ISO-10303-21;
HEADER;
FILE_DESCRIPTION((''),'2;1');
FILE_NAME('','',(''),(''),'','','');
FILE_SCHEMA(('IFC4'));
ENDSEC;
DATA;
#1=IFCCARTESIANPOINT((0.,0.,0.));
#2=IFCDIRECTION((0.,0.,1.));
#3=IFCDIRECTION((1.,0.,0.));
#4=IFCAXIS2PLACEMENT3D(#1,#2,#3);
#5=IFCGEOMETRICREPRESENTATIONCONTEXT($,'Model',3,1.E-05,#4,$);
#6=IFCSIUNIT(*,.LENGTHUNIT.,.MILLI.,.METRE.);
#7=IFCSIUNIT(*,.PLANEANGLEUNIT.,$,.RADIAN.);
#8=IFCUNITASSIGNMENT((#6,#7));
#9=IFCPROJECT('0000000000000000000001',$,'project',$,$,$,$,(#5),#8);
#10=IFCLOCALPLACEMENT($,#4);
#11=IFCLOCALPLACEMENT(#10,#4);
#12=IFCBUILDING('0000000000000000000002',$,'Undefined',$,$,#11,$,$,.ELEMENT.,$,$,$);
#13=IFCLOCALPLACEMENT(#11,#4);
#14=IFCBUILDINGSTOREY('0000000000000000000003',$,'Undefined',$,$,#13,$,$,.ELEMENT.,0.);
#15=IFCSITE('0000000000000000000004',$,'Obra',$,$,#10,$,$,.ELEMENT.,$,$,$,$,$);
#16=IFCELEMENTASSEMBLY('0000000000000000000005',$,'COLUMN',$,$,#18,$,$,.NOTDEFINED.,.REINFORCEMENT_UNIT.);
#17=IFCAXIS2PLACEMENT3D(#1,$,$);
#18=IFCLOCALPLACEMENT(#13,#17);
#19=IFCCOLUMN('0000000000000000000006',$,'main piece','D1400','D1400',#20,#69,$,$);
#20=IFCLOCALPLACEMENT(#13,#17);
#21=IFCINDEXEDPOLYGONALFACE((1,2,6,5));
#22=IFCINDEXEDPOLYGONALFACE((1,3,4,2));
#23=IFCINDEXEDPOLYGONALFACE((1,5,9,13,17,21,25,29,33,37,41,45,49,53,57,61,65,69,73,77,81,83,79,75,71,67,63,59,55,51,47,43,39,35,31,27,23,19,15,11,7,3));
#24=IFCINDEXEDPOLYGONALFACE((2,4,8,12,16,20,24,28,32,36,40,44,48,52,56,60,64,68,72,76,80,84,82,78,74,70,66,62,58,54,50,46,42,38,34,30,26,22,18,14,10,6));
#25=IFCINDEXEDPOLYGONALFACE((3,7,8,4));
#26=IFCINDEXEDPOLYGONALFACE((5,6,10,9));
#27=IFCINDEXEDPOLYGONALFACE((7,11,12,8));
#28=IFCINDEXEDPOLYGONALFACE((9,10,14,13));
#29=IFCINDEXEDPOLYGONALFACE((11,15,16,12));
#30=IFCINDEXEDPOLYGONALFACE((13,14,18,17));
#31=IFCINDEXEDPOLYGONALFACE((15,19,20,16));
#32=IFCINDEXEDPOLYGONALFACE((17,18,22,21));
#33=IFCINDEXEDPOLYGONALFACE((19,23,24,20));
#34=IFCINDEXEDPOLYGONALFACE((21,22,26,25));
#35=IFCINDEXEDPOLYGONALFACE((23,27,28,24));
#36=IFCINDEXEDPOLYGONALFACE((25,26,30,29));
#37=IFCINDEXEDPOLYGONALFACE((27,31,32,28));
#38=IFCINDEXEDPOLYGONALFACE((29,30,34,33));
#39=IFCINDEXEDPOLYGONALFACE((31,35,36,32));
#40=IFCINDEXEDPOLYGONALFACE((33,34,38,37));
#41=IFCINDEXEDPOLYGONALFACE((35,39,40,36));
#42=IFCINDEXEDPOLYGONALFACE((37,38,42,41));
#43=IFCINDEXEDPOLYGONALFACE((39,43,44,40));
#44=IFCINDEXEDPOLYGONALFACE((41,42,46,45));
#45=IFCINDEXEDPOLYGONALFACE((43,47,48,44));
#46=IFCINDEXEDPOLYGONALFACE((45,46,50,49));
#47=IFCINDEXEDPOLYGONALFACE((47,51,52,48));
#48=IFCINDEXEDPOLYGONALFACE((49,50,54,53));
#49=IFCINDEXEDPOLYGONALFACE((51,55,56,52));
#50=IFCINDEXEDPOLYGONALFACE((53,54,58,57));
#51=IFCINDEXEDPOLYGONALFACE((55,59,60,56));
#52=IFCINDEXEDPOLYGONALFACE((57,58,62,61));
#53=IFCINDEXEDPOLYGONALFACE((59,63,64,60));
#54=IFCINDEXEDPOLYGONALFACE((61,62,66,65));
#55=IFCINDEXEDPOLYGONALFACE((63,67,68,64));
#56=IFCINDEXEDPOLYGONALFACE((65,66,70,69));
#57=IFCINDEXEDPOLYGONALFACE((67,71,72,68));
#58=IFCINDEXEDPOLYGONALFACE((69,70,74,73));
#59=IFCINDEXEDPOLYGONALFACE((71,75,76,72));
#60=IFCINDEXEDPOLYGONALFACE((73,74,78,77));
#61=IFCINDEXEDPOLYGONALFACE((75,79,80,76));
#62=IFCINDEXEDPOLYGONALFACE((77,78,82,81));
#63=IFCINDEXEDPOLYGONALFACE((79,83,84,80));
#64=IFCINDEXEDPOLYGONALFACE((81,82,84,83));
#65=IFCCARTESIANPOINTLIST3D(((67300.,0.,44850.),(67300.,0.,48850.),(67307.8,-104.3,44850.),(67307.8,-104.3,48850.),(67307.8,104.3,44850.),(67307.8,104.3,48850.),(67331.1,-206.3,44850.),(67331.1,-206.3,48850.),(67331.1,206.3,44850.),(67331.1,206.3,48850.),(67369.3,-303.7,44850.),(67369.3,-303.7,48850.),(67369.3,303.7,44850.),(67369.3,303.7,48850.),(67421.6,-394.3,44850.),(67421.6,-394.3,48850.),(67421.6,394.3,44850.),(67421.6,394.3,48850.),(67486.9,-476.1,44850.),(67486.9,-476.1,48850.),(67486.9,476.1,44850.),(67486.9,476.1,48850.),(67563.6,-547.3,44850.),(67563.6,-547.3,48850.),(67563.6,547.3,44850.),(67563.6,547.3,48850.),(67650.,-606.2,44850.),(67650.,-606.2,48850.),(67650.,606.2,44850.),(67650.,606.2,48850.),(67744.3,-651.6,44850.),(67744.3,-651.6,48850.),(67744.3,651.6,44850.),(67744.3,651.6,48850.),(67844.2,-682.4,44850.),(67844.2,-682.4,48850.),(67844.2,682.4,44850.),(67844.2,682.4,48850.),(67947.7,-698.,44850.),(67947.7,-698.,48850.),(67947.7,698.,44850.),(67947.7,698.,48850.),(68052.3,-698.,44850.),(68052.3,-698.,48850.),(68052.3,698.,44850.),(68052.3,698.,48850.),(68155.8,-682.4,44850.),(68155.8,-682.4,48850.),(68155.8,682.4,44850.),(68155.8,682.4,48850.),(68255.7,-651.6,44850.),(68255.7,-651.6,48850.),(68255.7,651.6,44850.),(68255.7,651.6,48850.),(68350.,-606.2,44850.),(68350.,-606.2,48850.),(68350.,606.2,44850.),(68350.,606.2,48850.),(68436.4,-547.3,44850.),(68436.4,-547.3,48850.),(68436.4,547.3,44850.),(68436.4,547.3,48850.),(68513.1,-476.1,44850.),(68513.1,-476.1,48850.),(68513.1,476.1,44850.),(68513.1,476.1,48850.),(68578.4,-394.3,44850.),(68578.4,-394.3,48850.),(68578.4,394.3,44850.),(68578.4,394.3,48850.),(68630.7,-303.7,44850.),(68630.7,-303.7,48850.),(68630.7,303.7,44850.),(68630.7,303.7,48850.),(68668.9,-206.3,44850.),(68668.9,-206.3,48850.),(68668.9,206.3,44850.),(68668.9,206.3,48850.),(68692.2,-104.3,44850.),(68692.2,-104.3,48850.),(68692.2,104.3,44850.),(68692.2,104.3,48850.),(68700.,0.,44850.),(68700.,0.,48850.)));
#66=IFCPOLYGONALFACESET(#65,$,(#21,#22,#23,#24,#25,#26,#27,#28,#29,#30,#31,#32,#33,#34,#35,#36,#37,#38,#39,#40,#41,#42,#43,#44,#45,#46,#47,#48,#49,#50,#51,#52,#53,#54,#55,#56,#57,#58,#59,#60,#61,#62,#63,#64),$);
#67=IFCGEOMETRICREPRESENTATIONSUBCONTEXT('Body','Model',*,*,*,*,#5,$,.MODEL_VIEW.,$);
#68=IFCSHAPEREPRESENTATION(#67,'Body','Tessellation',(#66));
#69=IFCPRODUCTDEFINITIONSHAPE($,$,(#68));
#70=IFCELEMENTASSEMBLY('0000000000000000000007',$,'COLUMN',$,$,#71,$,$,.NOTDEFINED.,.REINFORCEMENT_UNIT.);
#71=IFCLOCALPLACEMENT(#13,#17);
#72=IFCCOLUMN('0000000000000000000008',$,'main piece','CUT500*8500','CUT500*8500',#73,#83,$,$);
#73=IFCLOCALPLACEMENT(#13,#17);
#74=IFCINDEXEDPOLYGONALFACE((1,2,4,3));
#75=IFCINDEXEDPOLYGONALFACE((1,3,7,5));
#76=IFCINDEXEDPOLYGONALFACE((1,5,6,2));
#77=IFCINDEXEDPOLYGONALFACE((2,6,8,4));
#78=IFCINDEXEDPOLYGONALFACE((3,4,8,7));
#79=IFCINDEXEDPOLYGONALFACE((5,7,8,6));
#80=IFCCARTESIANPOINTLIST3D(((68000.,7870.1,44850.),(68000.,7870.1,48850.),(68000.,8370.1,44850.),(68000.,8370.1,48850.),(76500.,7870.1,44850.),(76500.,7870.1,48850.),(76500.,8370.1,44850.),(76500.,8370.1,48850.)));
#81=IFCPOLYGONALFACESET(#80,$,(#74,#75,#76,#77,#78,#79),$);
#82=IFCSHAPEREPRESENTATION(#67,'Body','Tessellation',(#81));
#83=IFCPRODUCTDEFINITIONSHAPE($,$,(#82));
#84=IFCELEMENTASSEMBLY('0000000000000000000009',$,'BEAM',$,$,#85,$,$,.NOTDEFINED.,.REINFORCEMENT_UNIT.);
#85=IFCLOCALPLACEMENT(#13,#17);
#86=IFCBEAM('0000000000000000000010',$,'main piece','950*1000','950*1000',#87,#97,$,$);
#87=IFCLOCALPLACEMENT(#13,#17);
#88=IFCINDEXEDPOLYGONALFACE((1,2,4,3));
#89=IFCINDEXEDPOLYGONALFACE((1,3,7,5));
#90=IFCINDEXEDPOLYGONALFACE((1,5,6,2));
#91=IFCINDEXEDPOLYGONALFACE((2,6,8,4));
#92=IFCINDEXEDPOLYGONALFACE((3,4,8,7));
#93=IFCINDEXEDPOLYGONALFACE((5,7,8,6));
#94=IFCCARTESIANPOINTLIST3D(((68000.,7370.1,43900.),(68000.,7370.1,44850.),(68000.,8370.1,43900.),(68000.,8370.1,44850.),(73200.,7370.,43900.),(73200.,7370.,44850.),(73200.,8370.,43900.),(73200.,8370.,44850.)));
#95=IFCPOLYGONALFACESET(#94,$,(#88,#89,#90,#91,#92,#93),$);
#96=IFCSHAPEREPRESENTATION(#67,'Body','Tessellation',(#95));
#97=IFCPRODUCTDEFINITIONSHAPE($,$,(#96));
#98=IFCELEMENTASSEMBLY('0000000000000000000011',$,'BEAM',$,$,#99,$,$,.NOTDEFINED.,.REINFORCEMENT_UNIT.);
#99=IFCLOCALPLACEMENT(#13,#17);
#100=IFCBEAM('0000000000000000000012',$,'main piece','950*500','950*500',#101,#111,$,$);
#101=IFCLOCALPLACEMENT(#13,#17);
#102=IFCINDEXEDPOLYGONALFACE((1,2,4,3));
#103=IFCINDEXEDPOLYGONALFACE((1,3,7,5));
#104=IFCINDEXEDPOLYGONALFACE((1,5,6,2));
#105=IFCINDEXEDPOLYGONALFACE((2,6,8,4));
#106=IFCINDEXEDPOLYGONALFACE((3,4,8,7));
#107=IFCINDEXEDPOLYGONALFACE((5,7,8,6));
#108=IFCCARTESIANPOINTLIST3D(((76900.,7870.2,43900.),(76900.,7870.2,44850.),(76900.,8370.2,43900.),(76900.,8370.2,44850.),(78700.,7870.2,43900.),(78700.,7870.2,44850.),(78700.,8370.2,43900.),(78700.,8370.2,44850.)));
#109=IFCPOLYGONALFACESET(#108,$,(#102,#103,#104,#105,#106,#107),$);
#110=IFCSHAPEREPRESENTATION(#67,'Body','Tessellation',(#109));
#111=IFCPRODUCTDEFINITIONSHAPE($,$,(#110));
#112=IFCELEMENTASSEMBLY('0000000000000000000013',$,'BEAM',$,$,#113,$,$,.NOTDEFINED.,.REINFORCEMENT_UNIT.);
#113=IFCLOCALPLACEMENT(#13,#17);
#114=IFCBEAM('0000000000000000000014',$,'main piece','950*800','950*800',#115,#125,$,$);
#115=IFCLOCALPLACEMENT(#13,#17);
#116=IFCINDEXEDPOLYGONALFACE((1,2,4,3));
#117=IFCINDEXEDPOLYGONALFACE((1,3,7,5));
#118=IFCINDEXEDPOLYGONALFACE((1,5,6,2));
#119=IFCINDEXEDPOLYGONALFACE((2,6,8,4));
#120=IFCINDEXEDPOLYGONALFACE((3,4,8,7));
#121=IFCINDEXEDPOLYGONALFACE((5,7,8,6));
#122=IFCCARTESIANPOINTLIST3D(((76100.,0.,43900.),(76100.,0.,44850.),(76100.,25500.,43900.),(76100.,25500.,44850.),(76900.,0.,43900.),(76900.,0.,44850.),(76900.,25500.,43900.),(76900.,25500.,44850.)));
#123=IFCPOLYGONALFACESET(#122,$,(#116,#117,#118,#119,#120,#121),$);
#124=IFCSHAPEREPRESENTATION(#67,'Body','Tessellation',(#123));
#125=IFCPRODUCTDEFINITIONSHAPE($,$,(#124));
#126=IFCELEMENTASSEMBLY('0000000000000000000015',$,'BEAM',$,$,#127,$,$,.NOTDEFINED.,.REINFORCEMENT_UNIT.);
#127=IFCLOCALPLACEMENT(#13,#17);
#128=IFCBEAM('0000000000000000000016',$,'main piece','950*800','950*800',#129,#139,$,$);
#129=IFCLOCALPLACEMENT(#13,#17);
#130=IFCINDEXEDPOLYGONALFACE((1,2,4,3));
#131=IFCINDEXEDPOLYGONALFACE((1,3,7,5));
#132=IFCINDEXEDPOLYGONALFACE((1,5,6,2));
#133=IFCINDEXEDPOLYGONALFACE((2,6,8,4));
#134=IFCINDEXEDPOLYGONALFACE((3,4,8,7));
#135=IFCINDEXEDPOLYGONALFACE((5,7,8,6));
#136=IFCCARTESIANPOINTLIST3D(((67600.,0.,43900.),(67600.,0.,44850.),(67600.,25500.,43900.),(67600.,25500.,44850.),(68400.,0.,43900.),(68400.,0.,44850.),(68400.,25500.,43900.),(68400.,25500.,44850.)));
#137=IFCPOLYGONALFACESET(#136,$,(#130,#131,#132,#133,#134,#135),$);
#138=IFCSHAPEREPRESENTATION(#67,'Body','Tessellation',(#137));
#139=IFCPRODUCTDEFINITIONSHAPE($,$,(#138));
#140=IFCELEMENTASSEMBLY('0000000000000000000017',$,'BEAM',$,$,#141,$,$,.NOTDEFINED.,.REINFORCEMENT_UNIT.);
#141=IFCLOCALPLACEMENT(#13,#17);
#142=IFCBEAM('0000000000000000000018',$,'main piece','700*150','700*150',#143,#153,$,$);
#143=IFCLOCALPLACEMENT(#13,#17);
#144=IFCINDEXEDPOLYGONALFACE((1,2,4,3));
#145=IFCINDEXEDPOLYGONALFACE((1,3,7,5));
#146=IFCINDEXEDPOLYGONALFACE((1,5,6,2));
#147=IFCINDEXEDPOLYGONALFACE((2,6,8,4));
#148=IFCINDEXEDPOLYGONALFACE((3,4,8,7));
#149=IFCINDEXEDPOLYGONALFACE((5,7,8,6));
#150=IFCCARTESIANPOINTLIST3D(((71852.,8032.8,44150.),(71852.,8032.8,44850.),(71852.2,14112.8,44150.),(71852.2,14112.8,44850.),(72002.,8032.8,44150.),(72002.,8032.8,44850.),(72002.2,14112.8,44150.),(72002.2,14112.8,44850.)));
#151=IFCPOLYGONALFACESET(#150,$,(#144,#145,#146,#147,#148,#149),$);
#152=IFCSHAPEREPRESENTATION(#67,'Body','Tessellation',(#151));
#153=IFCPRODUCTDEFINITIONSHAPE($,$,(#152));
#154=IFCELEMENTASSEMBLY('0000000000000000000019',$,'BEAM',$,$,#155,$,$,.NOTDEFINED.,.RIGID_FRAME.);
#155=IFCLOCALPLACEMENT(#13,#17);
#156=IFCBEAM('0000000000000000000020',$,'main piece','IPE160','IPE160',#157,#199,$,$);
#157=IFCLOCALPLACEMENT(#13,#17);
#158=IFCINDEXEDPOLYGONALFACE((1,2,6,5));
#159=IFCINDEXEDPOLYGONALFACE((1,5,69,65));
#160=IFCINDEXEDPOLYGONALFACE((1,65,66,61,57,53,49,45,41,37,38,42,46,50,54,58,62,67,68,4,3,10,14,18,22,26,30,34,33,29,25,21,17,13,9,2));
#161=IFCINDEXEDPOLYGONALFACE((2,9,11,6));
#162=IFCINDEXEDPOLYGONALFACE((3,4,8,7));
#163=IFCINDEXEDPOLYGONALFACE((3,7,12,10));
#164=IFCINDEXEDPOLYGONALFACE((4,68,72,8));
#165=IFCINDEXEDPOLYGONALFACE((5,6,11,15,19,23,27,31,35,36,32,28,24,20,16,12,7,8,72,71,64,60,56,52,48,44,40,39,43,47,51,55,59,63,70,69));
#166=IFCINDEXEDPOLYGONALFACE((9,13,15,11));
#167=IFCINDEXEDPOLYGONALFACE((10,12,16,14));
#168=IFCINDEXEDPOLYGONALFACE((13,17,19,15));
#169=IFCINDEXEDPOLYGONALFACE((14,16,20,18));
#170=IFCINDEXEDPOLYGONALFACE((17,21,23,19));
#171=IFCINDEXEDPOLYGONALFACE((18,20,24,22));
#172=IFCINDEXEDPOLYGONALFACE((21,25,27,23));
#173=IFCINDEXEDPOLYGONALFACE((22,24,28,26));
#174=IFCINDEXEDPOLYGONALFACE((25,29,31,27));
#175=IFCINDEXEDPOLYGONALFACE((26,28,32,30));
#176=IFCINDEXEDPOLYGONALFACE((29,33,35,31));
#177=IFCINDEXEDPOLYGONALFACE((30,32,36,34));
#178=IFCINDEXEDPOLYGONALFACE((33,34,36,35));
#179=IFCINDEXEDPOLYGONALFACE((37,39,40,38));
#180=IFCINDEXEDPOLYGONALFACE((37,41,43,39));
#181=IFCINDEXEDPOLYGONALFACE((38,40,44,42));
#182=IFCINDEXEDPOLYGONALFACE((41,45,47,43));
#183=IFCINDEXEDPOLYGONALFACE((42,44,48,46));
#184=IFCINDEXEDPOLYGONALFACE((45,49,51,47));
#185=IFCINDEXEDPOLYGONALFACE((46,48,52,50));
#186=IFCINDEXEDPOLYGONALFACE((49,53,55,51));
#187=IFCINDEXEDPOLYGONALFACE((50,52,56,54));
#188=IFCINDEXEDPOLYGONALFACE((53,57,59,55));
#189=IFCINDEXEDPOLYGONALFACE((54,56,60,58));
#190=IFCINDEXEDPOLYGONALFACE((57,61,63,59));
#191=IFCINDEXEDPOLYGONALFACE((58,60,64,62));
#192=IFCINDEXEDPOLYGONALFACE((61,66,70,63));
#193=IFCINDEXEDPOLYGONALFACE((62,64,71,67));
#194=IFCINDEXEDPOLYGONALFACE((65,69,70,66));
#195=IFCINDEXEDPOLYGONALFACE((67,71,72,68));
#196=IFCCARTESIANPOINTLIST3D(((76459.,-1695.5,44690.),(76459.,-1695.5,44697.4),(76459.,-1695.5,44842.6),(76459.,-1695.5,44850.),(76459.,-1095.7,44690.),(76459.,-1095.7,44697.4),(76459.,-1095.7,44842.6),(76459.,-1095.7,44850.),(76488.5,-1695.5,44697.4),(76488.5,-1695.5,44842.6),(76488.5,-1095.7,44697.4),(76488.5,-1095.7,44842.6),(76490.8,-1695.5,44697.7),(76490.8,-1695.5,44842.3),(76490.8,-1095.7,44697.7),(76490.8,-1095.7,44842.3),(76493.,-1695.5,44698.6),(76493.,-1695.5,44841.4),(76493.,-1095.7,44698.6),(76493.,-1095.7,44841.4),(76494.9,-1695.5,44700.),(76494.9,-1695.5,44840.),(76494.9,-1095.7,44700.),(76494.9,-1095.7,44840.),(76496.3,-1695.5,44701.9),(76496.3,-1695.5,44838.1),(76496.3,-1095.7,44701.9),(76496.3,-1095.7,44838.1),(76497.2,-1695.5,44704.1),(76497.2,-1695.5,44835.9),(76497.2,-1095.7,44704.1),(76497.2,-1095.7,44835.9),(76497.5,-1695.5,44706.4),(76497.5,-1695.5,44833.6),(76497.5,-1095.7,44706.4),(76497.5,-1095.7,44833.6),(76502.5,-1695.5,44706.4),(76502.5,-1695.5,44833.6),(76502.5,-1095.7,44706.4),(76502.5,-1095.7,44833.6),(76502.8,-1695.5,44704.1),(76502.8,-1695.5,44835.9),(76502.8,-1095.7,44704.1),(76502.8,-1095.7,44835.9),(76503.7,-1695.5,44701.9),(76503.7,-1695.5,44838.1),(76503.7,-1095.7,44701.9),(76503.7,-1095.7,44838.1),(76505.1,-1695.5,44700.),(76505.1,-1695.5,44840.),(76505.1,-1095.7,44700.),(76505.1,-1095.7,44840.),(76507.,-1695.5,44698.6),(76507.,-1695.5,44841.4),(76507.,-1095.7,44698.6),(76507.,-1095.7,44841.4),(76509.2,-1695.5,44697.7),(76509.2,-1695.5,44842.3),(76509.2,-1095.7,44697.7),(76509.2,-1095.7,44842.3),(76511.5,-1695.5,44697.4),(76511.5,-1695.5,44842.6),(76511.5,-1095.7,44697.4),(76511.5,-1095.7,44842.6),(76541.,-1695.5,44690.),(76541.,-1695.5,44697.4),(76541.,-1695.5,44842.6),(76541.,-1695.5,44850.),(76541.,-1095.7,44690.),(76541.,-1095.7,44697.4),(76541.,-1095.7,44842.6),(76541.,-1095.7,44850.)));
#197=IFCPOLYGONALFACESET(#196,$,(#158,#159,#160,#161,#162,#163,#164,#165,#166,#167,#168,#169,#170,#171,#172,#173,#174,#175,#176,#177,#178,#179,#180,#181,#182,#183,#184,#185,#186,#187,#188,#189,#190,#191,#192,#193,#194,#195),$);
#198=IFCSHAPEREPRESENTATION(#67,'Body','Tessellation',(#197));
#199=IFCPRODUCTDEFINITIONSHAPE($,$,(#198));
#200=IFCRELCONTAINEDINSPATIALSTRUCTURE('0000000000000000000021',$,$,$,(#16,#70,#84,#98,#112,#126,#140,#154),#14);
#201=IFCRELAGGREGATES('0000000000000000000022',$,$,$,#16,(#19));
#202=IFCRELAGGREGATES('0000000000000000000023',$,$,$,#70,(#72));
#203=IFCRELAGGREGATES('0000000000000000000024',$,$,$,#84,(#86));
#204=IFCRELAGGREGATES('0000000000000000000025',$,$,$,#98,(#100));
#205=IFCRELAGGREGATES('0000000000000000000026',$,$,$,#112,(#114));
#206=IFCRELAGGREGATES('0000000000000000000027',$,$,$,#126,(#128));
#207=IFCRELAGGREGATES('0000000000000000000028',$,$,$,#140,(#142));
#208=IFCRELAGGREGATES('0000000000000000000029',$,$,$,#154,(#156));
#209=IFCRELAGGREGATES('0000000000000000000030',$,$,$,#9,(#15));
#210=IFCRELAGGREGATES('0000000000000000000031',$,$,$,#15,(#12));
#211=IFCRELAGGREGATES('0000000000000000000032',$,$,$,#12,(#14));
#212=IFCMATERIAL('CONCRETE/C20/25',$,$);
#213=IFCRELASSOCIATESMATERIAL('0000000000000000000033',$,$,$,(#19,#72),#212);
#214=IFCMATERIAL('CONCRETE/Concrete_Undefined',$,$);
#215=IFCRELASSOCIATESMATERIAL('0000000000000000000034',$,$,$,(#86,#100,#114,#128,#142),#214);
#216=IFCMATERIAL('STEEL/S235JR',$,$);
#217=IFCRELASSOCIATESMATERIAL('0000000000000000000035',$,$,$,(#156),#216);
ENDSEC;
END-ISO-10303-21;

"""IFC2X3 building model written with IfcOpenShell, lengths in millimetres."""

from ifc_helpers import new_model, si_unit, frame, origin_with_axes, origin_2d_with_axis, place, context, subcontext, project, spatial, rectangle, circle, i_section, extrude, material, element, aggregate, save


model = new_model("IFC2X3")

# Units and contexts
model_context = context("Model", 3, precision=1e-05, world=origin_with_axes())
body_context = subcontext(model_context, "Body", "Model", "MODEL_VIEW")
ifc_project = project(units=[si_unit("LENGTHUNIT", "METRE", prefix="MILLI"), si_unit("PLANEANGLEUNIT", "RADIAN")], contexts=[model_context])

# Site, building, storey
site_placement = place(None, origin_with_axes())
site = spatial("IfcSite", under=ifc_project, at=site_placement, Name="Obra", CompositionType="ELEMENT")
building_placement = place(site_placement, origin_with_axes())
building = spatial("IfcBuilding", under=site, at=building_placement, Name="Undefined", CompositionType="ELEMENT")
storey_placement = place(building_placement, origin_with_axes())
storey = spatial("IfcBuildingStorey", under=building, at=storey_placement, Name="Undefined", CompositionType="ELEMENT", Elevation=0.0)

# Element assemblies, columns
ifc_material_1 = material(Name="CONCRETE/C20/25")
assembly_1_placement = place(storey_placement, origin_with_axes())
assembly_1 = element("IfcElementAssembly", 1, at=assembly_1_placement, inside=storey, Name="COLUMN", AssemblyPlace="NOTDEFINED", PredefinedType="REINFORCEMENT_UNIT")
column_1_placement = place(assembly_1_placement, frame((68000.0, 0.0, 44850.0), z_axis=(0.0, 0.0, 1.0), x_axis=(0.0, 1.0, 0.0)))
column_1 = element("IfcColumn", 2, at=column_1_placement, material=ifc_material_1, Name="main piece", Description="D1400", ObjectType="D1400", context=body_context, shape_type="SweptSolid", body=[
    extrude(circle(Radius=700.0, at=origin_2d_with_axis()), frame((0.0, 0.0, 4000.0), z_axis=(0.0, 0.0, -1.0), x_axis=(0.0, 1.0, 0.0)), (0.0, 0.0, 1.0), 4000.0),
])
aggregate(assembly_1, [column_1])
assembly_2_placement = place(storey_placement, origin_with_axes())
assembly_2 = element("IfcElementAssembly", 3, at=assembly_2_placement, inside=storey, Name="COLUMN", AssemblyPlace="NOTDEFINED", PredefinedType="REINFORCEMENT_UNIT")
column_2_placement = place(assembly_2_placement, frame((72250.0, 8120.1, 44850.0), z_axis=(0.0, 0.0, 1.0), x_axis=(-1.0, 0.0, 0.0)))
column_2 = element("IfcColumn", 4, at=column_2_placement, material=ifc_material_1, Name="main piece", Description="CUT500*8500", ObjectType="CUT500*8500", context=body_context, shape_type="SweptSolid", body=[
    extrude(rectangle(XDim=500.0, YDim=8500.0, at=origin_2d_with_axis()), frame((0.0, 0.0, 4000.0), z_axis=(0.0, 0.0, -1.0), x_axis=(0.0, 1.0, 0.0)), (0.0, 0.0, 1.0), 4000.0),
])
aggregate(assembly_2, [column_2])

# Element assemblies, beams
assembly_3_placement = place(storey_placement, origin_with_axes())
assembly_3 = element("IfcElementAssembly", 5, at=assembly_3_placement, inside=storey, Name="BEAM", AssemblyPlace="NOTDEFINED", PredefinedType="REINFORCEMENT_UNIT")
ifc_material_2 = material(Name="CONCRETE/Concrete_Undefined")
beam_1_placement = place(assembly_3_placement, frame((68000.0, 7870.1, 44375.0), z_axis=(0.0, 0.0, 1.0), x_axis=(1.0, -0.000019, 0.0)))
beam_1 = element("IfcBeam", 6, at=beam_1_placement, material=ifc_material_2, Name="main piece", Description="950*1000", ObjectType="950*1000", context=body_context, shape_type="SweptSolid", body=[
    extrude(rectangle(XDim=1000.0, YDim=950.0, at=origin_2d_with_axis()), frame((5200.0, 0.0, 0.0), z_axis=(-1.0, 0.0, 0.0), x_axis=(0.0, -1.0, 0.0)), (0.0, 0.0, 1.0), 5200.0),
])
aggregate(assembly_3, [beam_1])
assembly_4_placement = place(storey_placement, origin_with_axes())
assembly_4 = element("IfcElementAssembly", 7, at=assembly_4_placement, inside=storey, Name="BEAM", AssemblyPlace="NOTDEFINED", PredefinedType="REINFORCEMENT_UNIT")
beam_2_placement = place(assembly_4_placement, frame((78700.0, 8120.2, 44375.0), z_axis=(0.0, 0.0, 1.0), x_axis=(-1.0, 0.0, 0.0)))
beam_2 = element("IfcBeam", 8, at=beam_2_placement, material=ifc_material_2, Name="main piece", Description="950*500", ObjectType="950*500", context=body_context, shape_type="SweptSolid", body=[
    extrude(rectangle(XDim=500.0, YDim=950.0, at=origin_2d_with_axis()), frame((1800.0, 0.0, 0.0), z_axis=(-1.0, 0.0, 0.0), x_axis=(0.0, -1.0, 0.0)), (0.0, 0.0, 1.0), 1800.0),
])
aggregate(assembly_4, [beam_2])
assembly_5_placement = place(storey_placement, origin_with_axes())
assembly_5 = element("IfcElementAssembly", 9, at=assembly_5_placement, inside=storey, Name="BEAM", AssemblyPlace="NOTDEFINED", PredefinedType="REINFORCEMENT_UNIT")
beam_3_placement = place(assembly_5_placement, frame((76500.0, 0.0, 44375.0), z_axis=(0.0, 0.0, 1.0), x_axis=(0.0, 1.0, 0.0)))
beam_3 = element("IfcBeam", 10, at=beam_3_placement, material=ifc_material_2, Name="main piece", Description="950*800", ObjectType="950*800", context=body_context, shape_type="SweptSolid", body=[
    extrude(rectangle(XDim=800.0, YDim=950.0, at=origin_2d_with_axis()), frame((25500.0, 0.0, 0.0), z_axis=(-1.0, 0.0, 0.0), x_axis=(0.0, -1.0, 0.0)), (0.0, 0.0, 1.0), 25500.0),
])
aggregate(assembly_5, [beam_3])
assembly_6_placement = place(storey_placement, origin_with_axes())
assembly_6 = element("IfcElementAssembly", 11, at=assembly_6_placement, inside=storey, Name="BEAM", AssemblyPlace="NOTDEFINED", PredefinedType="REINFORCEMENT_UNIT")
beam_4_placement = place(assembly_6_placement, frame((68000.0, 0.0, 44375.0), z_axis=(0.0, 0.0, 1.0), x_axis=(0.0, 1.0, 0.0)))
beam_4 = element("IfcBeam", 12, at=beam_4_placement, material=ifc_material_2, Name="main piece", Description="950*800", ObjectType="950*800", context=body_context, shape_type="SweptSolid", body=[
    extrude(rectangle(XDim=800.0, YDim=950.0, at=origin_2d_with_axis()), frame((25500.0, 0.0, 0.0), z_axis=(-1.0, 0.0, 0.0), x_axis=(0.0, -1.0, 0.0)), (0.0, 0.0, 1.0), 25500.0),
])
aggregate(assembly_6, [beam_4])
assembly_7_placement = place(storey_placement, origin_with_axes())
assembly_7 = element("IfcElementAssembly", 13, at=assembly_7_placement, inside=storey, Name="BEAM", AssemblyPlace="NOTDEFINED", PredefinedType="REINFORCEMENT_UNIT")
beam_5_placement = place(assembly_7_placement, frame((71927.0, 8032.8, 44500.0), z_axis=(0.0, 0.0, 1.0), x_axis=(0.000033, 1.0, 0.0)))
beam_5 = element("IfcBeam", 14, at=beam_5_placement, material=ifc_material_2, Name="main piece", Description="700*150", ObjectType="700*150", context=body_context, shape_type="SweptSolid", body=[
    extrude(rectangle(XDim=150.0, YDim=700.0, at=origin_2d_with_axis()), frame((6080.0, 0.0, 0.0), z_axis=(-1.0, 0.0, 0.0), x_axis=(0.0, -1.0, 0.0)), (0.0, 0.0, 1.0), 6080.0),
])
aggregate(assembly_7, [beam_5])
assembly_8_placement = place(storey_placement, origin_with_axes())
assembly_8 = element("IfcElementAssembly", 15, at=assembly_8_placement, inside=storey, Name="BEAM", AssemblyPlace="NOTDEFINED", PredefinedType="RIGID_FRAME")
ifc_material_3 = material(Name="STEEL/S235JR")
beam_6_placement = place(assembly_8_placement, frame((76500.0, -1095.7, 44770.0), z_axis=(0.0, 0.0, 1.0), x_axis=(0.0, -1.0, 0.0)))
beam_6 = element("IfcBeam", 16, at=beam_6_placement, material=ifc_material_3, Name="main piece", Description="IPE160", ObjectType="IPE160", context=body_context, shape_type="SweptSolid", body=[
    extrude(i_section(OverallWidth=82.0, OverallDepth=160.0, WebThickness=5.0, FlangeThickness=7.4, FilletRadius=9.0, at=origin_2d_with_axis()), frame((599.8, 0.0, 0.0), z_axis=(-1.0, 0.0, 0.0), x_axis=(0.0, -1.0, 0.0)), (0.0, 0.0, 1.0), 599.8),
])
aggregate(assembly_8, [beam_6])

save(model, "model.ifc")
